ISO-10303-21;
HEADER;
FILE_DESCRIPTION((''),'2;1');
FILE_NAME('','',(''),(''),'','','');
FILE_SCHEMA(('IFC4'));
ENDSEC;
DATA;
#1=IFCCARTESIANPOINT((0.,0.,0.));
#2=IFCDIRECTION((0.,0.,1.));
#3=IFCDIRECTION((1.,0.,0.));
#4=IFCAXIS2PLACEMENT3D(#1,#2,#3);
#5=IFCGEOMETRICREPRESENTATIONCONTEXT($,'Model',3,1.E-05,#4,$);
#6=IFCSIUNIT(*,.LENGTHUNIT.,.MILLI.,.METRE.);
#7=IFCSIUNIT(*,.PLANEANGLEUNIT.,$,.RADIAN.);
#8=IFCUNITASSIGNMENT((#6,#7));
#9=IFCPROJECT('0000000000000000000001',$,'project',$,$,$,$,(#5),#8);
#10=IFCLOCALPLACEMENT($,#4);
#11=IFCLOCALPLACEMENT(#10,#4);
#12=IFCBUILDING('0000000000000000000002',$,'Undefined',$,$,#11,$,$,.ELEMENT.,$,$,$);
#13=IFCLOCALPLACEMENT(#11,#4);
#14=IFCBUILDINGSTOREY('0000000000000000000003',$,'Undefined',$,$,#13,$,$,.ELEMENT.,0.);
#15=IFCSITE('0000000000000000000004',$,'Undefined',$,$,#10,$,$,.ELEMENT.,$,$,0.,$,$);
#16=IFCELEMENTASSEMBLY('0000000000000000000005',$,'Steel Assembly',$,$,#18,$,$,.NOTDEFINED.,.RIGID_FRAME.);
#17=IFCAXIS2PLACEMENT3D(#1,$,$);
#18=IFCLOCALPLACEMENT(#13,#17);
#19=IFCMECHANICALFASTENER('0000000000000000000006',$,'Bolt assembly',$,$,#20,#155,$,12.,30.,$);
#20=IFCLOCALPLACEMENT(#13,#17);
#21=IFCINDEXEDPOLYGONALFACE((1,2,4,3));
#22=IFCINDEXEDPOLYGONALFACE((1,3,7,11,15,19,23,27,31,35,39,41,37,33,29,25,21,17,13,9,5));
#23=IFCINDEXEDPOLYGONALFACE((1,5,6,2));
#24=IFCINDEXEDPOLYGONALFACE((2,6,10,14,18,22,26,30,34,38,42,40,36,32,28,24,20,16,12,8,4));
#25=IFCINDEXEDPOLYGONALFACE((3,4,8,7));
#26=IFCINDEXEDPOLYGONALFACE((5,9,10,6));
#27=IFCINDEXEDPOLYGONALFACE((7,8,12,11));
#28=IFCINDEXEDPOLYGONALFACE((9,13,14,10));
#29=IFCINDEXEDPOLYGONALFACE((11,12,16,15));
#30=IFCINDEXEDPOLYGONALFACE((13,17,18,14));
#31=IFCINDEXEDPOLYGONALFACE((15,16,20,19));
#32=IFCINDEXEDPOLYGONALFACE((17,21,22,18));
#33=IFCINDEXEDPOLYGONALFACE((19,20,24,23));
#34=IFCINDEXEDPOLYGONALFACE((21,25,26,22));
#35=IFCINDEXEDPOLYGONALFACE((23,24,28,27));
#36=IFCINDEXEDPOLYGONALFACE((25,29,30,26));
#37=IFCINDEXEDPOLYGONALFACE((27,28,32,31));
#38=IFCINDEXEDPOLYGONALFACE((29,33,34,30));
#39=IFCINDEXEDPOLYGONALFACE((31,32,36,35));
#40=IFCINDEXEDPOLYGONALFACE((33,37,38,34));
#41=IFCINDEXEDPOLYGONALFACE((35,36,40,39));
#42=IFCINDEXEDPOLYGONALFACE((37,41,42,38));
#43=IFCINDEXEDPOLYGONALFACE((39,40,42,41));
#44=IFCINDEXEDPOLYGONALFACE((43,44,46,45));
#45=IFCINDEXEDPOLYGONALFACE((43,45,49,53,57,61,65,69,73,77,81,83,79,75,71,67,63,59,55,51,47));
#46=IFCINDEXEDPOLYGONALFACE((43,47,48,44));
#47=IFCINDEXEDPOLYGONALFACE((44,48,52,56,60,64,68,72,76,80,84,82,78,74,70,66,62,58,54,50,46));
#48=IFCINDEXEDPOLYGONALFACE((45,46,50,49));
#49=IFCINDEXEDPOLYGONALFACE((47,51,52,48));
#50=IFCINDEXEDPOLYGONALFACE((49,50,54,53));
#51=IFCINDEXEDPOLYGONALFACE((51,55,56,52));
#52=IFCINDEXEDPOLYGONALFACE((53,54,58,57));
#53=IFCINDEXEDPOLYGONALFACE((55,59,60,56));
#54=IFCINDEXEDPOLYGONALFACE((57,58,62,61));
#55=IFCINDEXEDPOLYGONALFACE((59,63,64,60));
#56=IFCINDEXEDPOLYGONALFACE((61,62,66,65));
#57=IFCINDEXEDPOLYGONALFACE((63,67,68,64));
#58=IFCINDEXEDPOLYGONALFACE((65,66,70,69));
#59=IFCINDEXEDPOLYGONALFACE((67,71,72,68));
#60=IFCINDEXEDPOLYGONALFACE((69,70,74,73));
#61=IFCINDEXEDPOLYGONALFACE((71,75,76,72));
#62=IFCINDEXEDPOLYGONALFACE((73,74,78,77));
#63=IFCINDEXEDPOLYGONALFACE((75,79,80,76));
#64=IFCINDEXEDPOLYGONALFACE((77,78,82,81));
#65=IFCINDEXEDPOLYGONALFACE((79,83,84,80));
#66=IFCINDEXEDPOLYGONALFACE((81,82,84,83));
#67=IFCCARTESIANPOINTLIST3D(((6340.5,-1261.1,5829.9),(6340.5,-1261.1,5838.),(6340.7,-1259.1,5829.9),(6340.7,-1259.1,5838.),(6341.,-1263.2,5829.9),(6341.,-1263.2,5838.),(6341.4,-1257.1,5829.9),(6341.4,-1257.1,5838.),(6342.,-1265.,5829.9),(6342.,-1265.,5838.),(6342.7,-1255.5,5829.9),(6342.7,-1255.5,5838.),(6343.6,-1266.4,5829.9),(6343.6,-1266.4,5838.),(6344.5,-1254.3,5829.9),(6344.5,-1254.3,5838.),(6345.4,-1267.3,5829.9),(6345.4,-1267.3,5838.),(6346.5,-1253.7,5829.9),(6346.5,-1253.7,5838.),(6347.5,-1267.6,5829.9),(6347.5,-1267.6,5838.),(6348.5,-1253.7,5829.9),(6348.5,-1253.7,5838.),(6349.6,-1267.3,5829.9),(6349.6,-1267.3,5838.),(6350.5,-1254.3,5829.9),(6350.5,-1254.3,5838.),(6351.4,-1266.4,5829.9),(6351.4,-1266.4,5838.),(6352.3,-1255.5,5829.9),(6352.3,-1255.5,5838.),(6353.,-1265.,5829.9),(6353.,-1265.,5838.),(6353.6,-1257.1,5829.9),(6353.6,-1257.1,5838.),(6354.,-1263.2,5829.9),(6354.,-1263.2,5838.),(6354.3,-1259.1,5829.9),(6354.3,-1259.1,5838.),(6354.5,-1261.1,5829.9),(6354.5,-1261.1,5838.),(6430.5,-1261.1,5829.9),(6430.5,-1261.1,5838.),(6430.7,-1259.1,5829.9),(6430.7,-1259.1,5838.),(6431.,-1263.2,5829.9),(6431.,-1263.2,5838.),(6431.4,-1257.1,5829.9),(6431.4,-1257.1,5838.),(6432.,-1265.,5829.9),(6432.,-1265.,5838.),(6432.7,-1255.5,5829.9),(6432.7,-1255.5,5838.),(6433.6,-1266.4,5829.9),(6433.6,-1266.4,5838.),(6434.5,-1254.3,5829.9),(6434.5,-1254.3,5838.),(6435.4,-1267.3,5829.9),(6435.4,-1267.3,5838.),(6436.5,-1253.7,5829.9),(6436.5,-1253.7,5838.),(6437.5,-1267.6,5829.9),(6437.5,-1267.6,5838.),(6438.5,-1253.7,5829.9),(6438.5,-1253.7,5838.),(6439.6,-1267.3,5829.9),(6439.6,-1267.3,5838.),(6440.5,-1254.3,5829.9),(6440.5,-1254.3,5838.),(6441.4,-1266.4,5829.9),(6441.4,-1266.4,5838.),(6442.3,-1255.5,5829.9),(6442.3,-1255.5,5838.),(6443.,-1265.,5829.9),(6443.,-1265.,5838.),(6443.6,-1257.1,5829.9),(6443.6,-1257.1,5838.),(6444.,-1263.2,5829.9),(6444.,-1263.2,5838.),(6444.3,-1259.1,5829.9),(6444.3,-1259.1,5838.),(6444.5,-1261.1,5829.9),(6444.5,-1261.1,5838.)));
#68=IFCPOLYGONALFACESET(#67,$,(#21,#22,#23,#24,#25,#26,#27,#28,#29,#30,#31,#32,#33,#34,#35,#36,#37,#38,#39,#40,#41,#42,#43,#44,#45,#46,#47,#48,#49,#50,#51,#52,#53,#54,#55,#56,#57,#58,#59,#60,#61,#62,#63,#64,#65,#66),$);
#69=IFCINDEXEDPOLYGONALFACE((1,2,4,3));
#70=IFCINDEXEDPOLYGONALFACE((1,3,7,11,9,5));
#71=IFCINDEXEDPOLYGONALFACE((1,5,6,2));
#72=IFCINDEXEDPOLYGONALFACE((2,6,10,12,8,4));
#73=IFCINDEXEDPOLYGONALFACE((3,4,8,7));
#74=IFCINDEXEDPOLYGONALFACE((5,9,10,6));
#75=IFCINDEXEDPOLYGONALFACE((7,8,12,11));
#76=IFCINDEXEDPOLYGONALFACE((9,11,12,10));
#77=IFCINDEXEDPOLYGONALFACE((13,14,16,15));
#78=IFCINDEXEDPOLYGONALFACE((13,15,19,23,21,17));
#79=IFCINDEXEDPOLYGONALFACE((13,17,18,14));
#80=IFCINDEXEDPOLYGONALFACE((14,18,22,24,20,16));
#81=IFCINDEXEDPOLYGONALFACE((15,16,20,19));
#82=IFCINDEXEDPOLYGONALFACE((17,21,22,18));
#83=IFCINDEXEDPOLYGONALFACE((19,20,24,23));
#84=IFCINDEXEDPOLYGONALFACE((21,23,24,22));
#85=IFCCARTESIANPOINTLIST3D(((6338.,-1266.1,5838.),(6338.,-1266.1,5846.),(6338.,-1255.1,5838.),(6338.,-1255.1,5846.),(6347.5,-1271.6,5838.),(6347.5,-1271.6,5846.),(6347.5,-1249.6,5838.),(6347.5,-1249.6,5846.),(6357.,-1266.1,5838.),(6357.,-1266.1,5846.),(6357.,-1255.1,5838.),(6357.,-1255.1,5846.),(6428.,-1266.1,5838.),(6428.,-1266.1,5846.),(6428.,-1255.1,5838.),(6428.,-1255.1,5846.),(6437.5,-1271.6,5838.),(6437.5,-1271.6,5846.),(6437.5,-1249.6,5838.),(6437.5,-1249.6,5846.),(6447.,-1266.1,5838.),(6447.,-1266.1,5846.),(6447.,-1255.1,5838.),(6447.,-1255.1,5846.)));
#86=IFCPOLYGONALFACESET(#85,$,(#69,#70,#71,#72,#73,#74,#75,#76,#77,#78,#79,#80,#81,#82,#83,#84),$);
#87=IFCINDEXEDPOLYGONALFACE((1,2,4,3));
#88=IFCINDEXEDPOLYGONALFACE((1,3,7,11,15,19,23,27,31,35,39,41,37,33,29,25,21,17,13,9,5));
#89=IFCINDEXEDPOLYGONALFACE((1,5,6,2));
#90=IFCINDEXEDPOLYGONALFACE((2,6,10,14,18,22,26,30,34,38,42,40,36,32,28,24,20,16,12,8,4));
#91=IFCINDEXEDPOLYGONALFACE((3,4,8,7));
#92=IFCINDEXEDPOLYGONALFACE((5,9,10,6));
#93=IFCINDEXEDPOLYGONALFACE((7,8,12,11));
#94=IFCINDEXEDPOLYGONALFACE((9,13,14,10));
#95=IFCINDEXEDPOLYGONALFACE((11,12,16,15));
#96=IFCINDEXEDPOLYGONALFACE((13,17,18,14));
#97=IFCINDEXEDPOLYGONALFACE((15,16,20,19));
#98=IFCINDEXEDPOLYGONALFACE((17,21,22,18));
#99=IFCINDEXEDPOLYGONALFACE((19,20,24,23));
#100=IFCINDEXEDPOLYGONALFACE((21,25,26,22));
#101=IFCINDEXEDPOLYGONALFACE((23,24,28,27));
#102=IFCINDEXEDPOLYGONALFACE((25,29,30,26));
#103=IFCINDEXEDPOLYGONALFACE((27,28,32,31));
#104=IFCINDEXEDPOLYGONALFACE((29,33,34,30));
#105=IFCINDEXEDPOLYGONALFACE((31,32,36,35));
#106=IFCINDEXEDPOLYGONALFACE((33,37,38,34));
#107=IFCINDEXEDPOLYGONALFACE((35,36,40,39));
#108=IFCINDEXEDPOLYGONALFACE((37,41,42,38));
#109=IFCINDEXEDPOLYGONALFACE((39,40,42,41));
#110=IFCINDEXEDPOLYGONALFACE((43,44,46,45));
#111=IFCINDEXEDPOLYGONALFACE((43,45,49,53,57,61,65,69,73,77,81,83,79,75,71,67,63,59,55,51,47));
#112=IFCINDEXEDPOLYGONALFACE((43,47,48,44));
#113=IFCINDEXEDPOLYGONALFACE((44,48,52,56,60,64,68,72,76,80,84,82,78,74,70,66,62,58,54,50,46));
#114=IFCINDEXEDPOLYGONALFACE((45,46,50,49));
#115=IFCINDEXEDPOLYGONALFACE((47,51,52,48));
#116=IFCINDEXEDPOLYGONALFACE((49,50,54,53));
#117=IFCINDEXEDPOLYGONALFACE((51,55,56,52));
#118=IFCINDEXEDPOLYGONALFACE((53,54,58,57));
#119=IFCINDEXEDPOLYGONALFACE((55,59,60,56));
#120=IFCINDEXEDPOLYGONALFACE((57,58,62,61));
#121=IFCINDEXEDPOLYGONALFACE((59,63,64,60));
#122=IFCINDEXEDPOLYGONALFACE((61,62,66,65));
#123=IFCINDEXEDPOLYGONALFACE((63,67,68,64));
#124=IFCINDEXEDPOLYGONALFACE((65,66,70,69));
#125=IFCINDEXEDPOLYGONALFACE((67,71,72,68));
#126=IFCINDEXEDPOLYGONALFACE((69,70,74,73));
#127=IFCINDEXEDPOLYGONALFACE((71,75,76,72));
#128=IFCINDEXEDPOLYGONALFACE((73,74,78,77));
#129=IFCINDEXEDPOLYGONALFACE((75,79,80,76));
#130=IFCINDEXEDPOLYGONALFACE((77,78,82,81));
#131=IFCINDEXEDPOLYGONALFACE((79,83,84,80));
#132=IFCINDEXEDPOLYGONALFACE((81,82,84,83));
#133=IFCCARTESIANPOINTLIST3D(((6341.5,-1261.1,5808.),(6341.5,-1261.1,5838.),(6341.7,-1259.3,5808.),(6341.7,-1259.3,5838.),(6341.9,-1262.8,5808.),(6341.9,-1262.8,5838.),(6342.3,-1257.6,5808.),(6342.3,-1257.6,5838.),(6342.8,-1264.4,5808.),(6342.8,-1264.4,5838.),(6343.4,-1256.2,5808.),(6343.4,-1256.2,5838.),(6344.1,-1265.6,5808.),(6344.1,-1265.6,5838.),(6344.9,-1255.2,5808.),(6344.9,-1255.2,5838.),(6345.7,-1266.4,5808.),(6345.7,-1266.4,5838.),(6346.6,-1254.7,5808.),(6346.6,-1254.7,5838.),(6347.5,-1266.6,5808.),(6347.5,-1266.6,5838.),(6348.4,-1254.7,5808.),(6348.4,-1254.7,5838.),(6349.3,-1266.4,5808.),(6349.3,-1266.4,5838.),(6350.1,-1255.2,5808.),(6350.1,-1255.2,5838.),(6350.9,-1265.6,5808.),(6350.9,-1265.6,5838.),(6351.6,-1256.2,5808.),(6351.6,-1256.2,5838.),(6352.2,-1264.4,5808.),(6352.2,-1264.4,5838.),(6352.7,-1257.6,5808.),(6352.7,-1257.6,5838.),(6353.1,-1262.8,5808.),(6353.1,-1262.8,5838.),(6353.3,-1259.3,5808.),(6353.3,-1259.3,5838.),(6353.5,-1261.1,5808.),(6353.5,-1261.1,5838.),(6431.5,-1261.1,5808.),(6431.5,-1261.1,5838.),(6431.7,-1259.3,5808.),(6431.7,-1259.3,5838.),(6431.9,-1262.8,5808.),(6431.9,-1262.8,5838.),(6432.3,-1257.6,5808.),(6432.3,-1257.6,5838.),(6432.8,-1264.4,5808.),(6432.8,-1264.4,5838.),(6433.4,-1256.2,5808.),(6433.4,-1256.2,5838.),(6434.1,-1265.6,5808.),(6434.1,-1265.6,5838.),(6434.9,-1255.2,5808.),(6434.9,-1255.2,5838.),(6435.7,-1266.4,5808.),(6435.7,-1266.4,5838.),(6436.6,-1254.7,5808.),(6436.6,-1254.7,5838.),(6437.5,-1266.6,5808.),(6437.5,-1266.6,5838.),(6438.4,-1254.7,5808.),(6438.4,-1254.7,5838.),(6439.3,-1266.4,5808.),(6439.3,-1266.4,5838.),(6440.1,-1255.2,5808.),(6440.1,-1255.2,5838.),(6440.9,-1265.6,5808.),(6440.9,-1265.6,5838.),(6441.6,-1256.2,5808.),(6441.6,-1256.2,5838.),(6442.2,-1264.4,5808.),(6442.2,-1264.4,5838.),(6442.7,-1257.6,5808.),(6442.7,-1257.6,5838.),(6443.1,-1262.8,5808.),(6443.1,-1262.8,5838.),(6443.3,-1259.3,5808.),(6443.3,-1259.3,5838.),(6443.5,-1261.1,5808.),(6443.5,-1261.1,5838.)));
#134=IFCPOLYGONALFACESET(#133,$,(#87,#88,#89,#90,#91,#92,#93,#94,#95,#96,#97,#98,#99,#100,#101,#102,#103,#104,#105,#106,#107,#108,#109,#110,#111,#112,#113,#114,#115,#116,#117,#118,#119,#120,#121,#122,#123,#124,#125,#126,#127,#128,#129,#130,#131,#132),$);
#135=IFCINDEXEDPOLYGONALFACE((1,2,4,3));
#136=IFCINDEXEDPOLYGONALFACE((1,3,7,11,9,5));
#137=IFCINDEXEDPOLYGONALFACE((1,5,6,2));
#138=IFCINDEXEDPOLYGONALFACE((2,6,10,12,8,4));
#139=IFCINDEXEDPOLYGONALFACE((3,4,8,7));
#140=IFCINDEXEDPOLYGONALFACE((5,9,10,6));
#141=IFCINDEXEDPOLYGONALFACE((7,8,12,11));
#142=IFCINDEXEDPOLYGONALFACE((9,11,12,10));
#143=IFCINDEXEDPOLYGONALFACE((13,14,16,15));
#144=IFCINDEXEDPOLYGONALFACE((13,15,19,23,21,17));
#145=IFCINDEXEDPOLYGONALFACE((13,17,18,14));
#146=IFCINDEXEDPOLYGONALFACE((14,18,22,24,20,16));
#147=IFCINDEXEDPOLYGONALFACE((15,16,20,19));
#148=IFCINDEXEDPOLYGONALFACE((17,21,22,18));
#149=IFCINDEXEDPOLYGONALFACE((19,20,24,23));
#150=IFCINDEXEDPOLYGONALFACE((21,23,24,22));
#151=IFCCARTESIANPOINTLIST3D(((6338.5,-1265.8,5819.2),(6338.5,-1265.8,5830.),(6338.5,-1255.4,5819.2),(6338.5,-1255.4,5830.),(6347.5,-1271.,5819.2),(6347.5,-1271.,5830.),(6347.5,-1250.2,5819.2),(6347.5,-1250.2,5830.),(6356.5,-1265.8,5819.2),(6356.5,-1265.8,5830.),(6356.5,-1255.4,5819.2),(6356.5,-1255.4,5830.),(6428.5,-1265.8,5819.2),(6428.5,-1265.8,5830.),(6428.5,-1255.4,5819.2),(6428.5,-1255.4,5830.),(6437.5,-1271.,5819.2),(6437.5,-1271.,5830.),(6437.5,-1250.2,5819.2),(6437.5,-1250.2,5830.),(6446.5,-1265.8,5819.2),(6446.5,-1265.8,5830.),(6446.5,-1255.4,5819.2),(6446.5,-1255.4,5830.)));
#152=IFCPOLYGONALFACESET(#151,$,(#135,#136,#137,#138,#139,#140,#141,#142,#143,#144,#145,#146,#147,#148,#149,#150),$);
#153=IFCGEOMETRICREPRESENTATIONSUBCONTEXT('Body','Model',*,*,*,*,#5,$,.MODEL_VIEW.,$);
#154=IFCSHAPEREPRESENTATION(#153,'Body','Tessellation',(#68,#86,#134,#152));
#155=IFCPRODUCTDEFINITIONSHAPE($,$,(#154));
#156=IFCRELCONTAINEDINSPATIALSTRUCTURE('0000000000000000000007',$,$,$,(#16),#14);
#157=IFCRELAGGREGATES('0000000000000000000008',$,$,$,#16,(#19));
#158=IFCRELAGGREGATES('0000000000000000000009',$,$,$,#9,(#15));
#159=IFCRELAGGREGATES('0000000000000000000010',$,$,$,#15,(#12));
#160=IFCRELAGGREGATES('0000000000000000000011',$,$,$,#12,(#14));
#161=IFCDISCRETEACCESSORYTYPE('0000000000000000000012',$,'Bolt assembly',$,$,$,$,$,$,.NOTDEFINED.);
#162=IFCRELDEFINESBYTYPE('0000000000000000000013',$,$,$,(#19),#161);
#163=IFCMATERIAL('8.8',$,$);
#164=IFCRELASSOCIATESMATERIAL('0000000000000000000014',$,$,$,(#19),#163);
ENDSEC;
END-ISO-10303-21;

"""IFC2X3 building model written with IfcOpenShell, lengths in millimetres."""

from ifc_helpers import new_model, si_unit, frame, origin_with_axes, origin_2d_with_axis, place, context, subcontext, project, spatial, polyline, circle, outline, extrude, source, transform, mapped, material, type_object, element, aggregate, save


model = new_model("IFC2X3")

# Units and contexts
model_context = context("Model", 3, precision=1e-05, world=origin_with_axes())
body_context = subcontext(model_context, "Body", "Model", "MODEL_VIEW")
ifc_project = project(units=[si_unit("LENGTHUNIT", "METRE", prefix="MILLI"), si_unit("PLANEANGLEUNIT", "RADIAN")], contexts=[model_context])

# Site, building, storey
site_placement = place(None, origin_with_axes())
site = spatial("IfcSite", under=ifc_project, at=site_placement, Name="Undefined", CompositionType="ELEMENT", RefElevation=0.0)
building_placement = place(site_placement, origin_with_axes())
building = spatial("IfcBuilding", under=site, at=building_placement, Name="Undefined", CompositionType="ELEMENT")
storey_placement = place(building_placement, origin_with_axes())
storey = spatial("IfcBuildingStorey", under=building, at=storey_placement, Name="Undefined", CompositionType="ELEMENT", Elevation=0.0)

# Element assembly
assembly_1_placement = place(storey_placement, origin_with_axes())
assembly_1 = element("IfcElementAssembly", 1, at=assembly_1_placement, inside=storey, Name="Steel Assembly", AssemblyPlace="NOTDEFINED", PredefinedType="RIGID_FRAME")

# Mechanical fastener
ifc_material_1 = material(Name="8.8")
discrete_accessory_type_1 = type_object("IfcDiscreteAccessoryType", Name="Bolt assembly")
shared_shape_1 = source(origin_with_axes(), body_context, "Body", "SweptSolid", [
    extrude(circle(Radius=7.0, at=origin_2d_with_axis()), frame((0.0, 0.0, 0.0), z_axis=(0.0, 1.0, 0.0), x_axis=(1.0, 0.0, 0.0)), (0.0, 0.0, 1.0), 8.1),
    extrude(outline(polyline([(11.0, 0.0), (5.5, 9.5), (-5.5, 9.5), (-11.0, 0.0), (-5.5, -9.5), (5.5, -9.5), (11.0, 0.0)])), frame((0.0, -8.0, 0.0), z_axis=(0.0, 1.0, 0.0), x_axis=(1.0, 0.0, 0.0)), (0.0, 0.0, 1.0), 8.0),
    extrude(circle(Radius=6.0, at=origin_2d_with_axis()), frame((0.0, 0.0, 0.0), z_axis=(0.0, 1.0, 0.0), x_axis=(1.0, 0.0, 0.0)), (0.0, 0.0, 1.0), 30.0),
    extrude(outline(polyline([(10.4, 0.0), (5.2, 9.0), (-5.2, 9.0), (-10.4, 0.0), (-5.2, -9.0), (5.2, -9.0), (10.4, 0.0)])), frame((0.0, 8.0, 0.0), z_axis=(0.0, 1.0, 0.0), x_axis=(1.0, 0.0, 0.0)), (0.0, 0.0, 1.0), 10.8),
])
mechanical_fastener_1_placement = place(assembly_1_placement, frame((6392.5, -1240.6, 5838.0), z_axis=(1.0, 0.0, 0.0), x_axis=(0.0, -1.0, 0.0)))
mechanical_fastener_1 = element("IfcMechanicalFastener", 2, at=mechanical_fastener_1_placement, type_object=discrete_accessory_type_1, material=ifc_material_1, Name="Bolt assembly", NominalDiameter=12.0, NominalLength=30.0, context=body_context, shape_type="MappedRepresentation", body=[
    mapped(shared_shape_1, transform((20.0, 0.0, -45.0))),
    mapped(shared_shape_1, transform((20.0, 0.0, 45.0))),
])

aggregate(assembly_1, [mechanical_fastener_1])

save(model, "model.ifc")
